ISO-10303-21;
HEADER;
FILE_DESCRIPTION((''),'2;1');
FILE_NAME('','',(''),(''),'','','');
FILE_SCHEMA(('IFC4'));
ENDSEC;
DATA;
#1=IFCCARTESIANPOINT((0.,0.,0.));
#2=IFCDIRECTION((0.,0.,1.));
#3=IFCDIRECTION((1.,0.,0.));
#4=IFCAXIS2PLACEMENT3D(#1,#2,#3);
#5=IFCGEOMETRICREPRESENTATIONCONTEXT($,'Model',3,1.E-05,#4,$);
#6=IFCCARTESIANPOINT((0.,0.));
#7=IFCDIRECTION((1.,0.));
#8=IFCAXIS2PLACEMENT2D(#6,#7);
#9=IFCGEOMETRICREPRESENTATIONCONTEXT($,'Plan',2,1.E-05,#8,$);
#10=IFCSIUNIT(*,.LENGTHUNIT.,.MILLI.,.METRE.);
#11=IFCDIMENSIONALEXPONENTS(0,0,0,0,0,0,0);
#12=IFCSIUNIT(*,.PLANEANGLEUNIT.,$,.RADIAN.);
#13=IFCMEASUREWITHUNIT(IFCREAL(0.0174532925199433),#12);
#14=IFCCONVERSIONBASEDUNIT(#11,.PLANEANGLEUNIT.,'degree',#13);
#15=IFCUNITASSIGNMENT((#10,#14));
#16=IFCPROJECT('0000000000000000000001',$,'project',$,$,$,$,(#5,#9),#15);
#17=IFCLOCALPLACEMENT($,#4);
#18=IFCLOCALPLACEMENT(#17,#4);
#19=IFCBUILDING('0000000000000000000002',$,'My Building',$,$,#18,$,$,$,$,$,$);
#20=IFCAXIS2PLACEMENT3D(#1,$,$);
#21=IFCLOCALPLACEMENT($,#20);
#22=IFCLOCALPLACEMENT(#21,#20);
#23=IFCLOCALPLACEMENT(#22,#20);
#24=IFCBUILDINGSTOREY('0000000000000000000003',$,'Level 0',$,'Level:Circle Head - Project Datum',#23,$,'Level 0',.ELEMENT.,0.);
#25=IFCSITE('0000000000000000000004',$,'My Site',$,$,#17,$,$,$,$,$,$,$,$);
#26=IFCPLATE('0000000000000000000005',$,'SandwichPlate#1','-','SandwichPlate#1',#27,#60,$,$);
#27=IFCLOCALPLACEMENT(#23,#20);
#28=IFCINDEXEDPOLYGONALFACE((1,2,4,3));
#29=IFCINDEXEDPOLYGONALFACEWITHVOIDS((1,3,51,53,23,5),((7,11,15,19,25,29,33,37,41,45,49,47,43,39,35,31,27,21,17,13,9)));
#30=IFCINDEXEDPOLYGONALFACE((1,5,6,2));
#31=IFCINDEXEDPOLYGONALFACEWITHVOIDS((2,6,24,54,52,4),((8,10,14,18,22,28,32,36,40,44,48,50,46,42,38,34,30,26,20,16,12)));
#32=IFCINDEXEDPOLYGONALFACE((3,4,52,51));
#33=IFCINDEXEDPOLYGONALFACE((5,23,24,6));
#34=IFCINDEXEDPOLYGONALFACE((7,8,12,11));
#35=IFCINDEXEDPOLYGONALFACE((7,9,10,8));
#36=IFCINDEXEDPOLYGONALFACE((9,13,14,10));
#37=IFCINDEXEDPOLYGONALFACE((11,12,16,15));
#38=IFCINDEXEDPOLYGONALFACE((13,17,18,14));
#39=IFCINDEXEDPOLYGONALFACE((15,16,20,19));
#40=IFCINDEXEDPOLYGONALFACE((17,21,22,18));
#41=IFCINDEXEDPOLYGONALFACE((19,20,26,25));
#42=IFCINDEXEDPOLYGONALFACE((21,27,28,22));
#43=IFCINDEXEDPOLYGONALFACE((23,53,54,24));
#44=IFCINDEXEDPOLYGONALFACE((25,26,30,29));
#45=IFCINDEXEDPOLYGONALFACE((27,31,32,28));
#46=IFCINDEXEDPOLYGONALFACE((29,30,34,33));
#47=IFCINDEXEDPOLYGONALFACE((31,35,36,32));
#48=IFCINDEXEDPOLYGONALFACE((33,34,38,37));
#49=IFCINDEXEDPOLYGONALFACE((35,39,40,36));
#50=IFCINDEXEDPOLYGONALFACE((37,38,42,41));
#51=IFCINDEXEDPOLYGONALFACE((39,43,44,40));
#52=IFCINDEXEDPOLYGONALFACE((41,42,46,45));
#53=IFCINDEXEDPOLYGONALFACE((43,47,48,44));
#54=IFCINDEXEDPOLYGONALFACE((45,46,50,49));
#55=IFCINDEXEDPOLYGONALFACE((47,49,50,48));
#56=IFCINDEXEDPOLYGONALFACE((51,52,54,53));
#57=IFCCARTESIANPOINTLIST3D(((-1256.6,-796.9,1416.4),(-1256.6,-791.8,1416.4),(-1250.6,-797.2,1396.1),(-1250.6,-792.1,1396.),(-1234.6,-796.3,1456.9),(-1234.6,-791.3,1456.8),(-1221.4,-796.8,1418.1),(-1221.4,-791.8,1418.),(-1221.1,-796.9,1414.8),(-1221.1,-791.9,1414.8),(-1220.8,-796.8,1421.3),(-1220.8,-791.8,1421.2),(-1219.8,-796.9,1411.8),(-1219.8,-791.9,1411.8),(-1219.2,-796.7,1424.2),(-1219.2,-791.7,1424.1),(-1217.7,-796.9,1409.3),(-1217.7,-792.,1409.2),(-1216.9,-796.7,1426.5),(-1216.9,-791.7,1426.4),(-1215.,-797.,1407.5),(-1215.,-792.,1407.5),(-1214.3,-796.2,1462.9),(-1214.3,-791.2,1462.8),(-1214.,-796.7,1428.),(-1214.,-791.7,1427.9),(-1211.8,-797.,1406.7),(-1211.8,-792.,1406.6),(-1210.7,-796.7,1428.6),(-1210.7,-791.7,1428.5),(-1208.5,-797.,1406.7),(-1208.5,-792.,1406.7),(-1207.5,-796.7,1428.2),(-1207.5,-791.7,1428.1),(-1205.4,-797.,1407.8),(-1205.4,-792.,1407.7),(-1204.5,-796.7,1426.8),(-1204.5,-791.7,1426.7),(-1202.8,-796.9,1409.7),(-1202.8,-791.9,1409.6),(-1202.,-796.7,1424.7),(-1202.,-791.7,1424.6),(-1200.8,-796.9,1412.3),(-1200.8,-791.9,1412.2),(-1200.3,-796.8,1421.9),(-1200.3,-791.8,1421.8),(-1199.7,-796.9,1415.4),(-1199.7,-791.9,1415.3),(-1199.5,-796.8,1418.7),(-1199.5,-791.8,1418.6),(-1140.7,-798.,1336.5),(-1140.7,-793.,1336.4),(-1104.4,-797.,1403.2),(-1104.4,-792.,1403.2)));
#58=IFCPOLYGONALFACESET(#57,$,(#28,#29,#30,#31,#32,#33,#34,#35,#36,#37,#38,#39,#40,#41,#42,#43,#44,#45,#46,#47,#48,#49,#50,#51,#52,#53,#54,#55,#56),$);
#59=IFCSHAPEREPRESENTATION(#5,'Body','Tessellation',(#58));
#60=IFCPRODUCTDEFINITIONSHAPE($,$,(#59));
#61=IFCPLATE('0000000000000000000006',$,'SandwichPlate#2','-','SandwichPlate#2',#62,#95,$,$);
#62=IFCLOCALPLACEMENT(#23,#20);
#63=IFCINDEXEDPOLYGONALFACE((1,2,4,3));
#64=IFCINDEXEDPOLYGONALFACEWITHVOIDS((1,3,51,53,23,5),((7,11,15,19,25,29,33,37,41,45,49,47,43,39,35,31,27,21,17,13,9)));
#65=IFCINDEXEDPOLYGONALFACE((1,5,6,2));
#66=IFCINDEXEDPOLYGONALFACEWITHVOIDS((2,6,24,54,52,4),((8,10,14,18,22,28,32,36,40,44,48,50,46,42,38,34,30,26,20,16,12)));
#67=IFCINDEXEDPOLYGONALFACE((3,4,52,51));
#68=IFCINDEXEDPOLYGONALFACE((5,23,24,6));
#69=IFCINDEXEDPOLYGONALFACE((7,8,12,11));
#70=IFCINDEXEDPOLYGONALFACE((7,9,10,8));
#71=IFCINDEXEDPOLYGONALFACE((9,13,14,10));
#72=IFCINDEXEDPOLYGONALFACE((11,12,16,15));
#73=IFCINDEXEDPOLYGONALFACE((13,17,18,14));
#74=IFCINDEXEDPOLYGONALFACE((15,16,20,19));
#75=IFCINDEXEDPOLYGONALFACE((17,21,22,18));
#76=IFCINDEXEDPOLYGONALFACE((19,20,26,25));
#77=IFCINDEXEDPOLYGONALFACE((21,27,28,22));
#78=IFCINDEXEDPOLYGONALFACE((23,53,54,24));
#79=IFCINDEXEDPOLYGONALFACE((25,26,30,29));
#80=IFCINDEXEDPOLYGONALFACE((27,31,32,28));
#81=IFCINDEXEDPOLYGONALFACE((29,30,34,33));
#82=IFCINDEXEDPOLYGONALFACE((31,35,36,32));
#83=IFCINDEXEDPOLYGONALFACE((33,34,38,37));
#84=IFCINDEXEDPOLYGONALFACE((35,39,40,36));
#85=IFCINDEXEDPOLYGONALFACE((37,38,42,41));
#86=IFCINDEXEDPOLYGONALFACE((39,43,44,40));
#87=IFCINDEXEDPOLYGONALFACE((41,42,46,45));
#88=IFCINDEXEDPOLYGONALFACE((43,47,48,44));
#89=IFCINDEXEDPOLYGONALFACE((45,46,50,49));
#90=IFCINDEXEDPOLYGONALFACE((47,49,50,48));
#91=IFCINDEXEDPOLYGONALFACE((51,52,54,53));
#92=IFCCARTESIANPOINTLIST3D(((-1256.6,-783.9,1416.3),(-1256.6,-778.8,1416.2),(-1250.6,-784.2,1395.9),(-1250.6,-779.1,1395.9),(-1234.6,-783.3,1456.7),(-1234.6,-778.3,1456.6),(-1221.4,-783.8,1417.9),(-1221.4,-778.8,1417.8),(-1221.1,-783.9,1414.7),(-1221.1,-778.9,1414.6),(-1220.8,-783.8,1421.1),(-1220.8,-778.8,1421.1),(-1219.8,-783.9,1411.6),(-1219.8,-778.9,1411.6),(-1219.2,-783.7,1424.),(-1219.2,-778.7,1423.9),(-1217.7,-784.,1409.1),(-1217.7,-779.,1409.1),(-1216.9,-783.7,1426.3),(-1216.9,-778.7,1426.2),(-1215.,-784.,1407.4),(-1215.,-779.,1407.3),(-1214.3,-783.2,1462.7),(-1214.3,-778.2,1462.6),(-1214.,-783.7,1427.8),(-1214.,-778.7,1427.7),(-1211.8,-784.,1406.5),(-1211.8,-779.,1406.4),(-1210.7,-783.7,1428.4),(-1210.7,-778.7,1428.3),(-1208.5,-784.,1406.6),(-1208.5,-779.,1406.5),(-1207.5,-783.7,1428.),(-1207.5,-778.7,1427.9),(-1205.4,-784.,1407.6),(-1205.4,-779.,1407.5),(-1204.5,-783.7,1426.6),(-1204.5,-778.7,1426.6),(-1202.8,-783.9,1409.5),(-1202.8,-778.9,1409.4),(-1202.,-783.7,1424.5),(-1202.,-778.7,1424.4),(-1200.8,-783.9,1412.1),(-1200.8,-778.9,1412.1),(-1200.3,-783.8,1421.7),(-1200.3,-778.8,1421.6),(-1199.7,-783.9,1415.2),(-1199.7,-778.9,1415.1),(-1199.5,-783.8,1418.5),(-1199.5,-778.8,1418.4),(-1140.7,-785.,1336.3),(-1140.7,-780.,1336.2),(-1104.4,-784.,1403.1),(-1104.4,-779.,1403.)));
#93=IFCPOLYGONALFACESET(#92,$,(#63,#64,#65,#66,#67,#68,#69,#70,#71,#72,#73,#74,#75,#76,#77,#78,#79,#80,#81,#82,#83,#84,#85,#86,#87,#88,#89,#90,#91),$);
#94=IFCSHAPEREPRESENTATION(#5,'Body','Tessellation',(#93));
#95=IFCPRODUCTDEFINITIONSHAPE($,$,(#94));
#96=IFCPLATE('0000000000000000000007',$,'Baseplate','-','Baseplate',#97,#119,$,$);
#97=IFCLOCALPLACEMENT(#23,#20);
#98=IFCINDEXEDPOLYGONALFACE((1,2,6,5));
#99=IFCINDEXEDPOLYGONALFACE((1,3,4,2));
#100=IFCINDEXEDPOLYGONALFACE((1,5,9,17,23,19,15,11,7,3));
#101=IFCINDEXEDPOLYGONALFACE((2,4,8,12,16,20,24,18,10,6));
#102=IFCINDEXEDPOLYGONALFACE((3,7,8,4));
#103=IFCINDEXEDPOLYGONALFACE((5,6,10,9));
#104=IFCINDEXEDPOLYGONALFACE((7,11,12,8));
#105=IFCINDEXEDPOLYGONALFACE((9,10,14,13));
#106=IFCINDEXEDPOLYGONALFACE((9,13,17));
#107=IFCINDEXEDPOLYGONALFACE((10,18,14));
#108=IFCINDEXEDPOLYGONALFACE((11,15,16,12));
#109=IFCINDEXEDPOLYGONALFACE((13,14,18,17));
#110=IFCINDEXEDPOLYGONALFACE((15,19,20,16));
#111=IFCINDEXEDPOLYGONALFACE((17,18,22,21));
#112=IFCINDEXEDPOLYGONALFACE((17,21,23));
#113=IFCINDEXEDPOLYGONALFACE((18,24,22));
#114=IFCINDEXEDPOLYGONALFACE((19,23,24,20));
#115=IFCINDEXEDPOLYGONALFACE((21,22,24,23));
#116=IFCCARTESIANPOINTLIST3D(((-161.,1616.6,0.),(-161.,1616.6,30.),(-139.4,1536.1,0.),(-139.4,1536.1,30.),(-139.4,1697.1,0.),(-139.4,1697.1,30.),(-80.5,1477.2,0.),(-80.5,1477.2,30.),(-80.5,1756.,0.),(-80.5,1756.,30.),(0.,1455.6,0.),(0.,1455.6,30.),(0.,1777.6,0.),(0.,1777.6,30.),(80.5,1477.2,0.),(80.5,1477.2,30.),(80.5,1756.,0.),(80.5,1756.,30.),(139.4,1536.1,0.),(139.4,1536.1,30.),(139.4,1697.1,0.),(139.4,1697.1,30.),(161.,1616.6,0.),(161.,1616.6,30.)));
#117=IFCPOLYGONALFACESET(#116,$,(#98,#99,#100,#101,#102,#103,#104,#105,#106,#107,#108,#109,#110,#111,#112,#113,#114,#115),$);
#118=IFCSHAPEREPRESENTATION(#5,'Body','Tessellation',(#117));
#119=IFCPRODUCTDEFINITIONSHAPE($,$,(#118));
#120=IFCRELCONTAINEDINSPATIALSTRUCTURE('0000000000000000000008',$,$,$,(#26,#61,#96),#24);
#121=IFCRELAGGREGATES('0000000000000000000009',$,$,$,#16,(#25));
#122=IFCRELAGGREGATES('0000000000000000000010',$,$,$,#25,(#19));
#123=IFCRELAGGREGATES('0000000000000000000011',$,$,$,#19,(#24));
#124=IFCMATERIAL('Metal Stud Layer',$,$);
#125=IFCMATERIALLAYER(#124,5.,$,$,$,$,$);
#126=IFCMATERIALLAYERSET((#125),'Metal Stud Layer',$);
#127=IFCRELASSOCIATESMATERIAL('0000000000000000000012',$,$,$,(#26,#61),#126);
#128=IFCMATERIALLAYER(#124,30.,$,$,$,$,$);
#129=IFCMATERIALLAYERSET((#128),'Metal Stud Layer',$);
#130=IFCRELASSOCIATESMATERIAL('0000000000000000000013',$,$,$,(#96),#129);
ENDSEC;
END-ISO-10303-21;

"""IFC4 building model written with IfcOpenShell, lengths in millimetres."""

from ifc_helpers import new_model, entity, si_unit, converted_unit, point, frame, frame_2d, origin, origin_with_axes, origin_2d_with_axis, place, context, project, spatial, polyline, circle_curve, line_curve, trimmed, segment, composite_curve, circle, outline, extrude, material, layer, layer_set, element, save


model = new_model("IFC4")

# Units and contexts
model_context = context("Model", 3, precision=1e-05, world=origin_with_axes())
plan_context = context("Plan", 2, precision=1e-05, world=origin_2d_with_axis())
ifc_project = project(units=[si_unit("LENGTHUNIT", "METRE", prefix="MILLI"), converted_unit("PLANEANGLEUNIT", "degree", entity("IfcReal", 0.0174532925199433), si_unit("PLANEANGLEUNIT", "RADIAN"), dimensions=[0, 0, 0, 0, 0, 0, 0])], contexts=[model_context, plan_context])

# Site, building, storey
site_placement = place(None, origin_with_axes())
site = spatial("IfcSite", under=ifc_project, at=site_placement, Name="My Site")
building_placement = place(site_placement, origin_with_axes())
building = spatial("IfcBuilding", under=site, at=building_placement, Name="My Building")
placement_1 = place(None, origin())
placement_2 = place(placement_1, origin())
storey_placement = place(placement_2, origin())
storey = spatial("IfcBuildingStorey", under=building, at=storey_placement, Name="Level 0", ObjectType="Level:Circle Head - Project Datum", LongName="Level 0", CompositionType="ELEMENT", Elevation=0.0)

# Shared definitions
ifc_material_1 = material(Name="Metal Stud Layer")
ifc_layer_1 = layer(ifc_material_1, 5.0)
ifc_layer_set_1 = layer_set([ifc_layer_1], Name="Metal Stud Layer")

# Plates, openings
plate_1_placement = place(storey_placement, frame((-1263.7, -797.0, 1403.3), z_axis=(0.0, 0.999896, -0.014432), x_axis=(0.477218, 0.012683, 0.878693)))
plate_1 = element("IfcPlate", 1, at=plate_1_placement, inside=storey, material=ifc_layer_set_1, Name="SandwichPlate#1", Description="-", ObjectType="SandwichPlate#1", context=model_context, shape_type="SweptSolid", body=[
    extrude(outline(polyline([(0.0, 0.0), (76.0, 0.0), (76.0, 140.0), (0.0, 140.0), (0.0, 0.0)])), origin_with_axes(), (0.0, 0.0, 1.0), 5.0),
])
opening_1_placement = place(plate_1_placement, frame((0.0, 0.0, 0.0), z_axis=(0.0, 0.0, 1.0), x_axis=(1.0, 0.0, 0.0)))
element("IfcOpeningElement", 2, at=opening_1_placement, cuts=plate_1, ObjectType="Opening", context=model_context, shape_type="SweptSolid", body=[
    extrude(outline(polyline([(76.0, 0.0), (76.0, 15.0), (61.0, 0.0), (76.0, 0.0)])), origin(), (0.0, 0.0, 1.0), 5.0),
])
opening_2_placement = place(plate_1_placement, frame((38.0, 40.0, -0.5), z_axis=(0.0, 0.0, 1.0), x_axis=(0.0, 1.0, 0.0)))
element("IfcOpeningElement", 3, at=opening_2_placement, cuts=plate_1, ObjectType="Opening", context=model_context, shape_type="SweptSolid", body=[
    extrude(circle(Radius=11.0, at=origin_2d_with_axis()), origin(), (0.0, 0.0, 1.0), 6.0),
])
opening_3_placement = place(plate_1_placement, frame((0.0, 0.0, 0.0), z_axis=(0.0, 0.0, 1.0), x_axis=(1.0, 0.0, 0.0)))
element("IfcOpeningElement", 4, at=opening_3_placement, cuts=plate_1, ObjectType="Opening", context=model_context, shape_type="SweptSolid", body=[
    extrude(outline(polyline([(0.0, 0.0), (15.0, 0.0), (0.0, 15.0), (0.0, 0.0)])), origin(), (0.0, 0.0, 1.0), 5.0),
])
plate_2_placement = place(storey_placement, frame((-1263.7, -784.0, 1403.1), z_axis=(0.0, 0.999896, -0.014432), x_axis=(0.477218, 0.012683, 0.878693)))
plate_2 = element("IfcPlate", 5, at=plate_2_placement, inside=storey, material=ifc_layer_set_1, Name="SandwichPlate#2", Description="-", ObjectType="SandwichPlate#2", context=model_context, shape_type="SweptSolid", body=[
    extrude(outline(polyline([(0.0, 0.0), (76.0, 0.0), (76.0, 140.0), (0.0, 140.0), (0.0, 0.0)])), origin_with_axes(), (0.0, 0.0, 1.0), 5.0),
])
opening_4_placement = place(plate_2_placement, frame((0.0, 0.0, 0.0), z_axis=(0.0, 0.0, 1.0), x_axis=(1.0, 0.0, 0.0)))
element("IfcOpeningElement", 6, at=opening_4_placement, cuts=plate_2, ObjectType="Opening", context=model_context, shape_type="SweptSolid", body=[
    extrude(outline(polyline([(76.0, 0.0), (76.0, 15.0), (61.0, 0.0), (76.0, 0.0)])), origin(), (0.0, 0.0, 1.0), 5.0),
])
opening_5_placement = place(plate_2_placement, frame((38.0, 40.0, -0.5), z_axis=(0.0, 0.0, 1.0), x_axis=(0.0, 1.0, 0.0)))
element("IfcOpeningElement", 7, at=opening_5_placement, cuts=plate_2, ObjectType="Opening", context=model_context, shape_type="SweptSolid", body=[
    extrude(circle(Radius=11.0, at=origin_2d_with_axis()), origin(), (0.0, 0.0, 1.0), 6.0),
])
opening_6_placement = place(plate_2_placement, frame((0.0, 0.0, 0.0), z_axis=(0.0, 0.0, 1.0), x_axis=(1.0, 0.0, 0.0)))
element("IfcOpeningElement", 8, at=opening_6_placement, cuts=plate_2, ObjectType="Opening", context=model_context, shape_type="SweptSolid", body=[
    extrude(outline(polyline([(0.0, 0.0), (15.0, 0.0), (0.0, 15.0), (0.0, 0.0)])), origin(), (0.0, 0.0, 1.0), 5.0),
])
ifc_layer_2 = layer(ifc_material_1, 30.0)
ifc_layer_set_2 = layer_set([ifc_layer_2], Name="Metal Stud Layer")
plate_3_placement = place(storey_placement, frame((-161.0, 1616.6, 30.0), z_axis=(0.0, 0.0, -1.0), x_axis=(0.0, 1.0, 0.0)))
plate_3 = element("IfcPlate", 9, at=plate_3_placement, inside=storey, material=ifc_layer_set_2, Name="Baseplate", Description="-", ObjectType="Baseplate", context=model_context, shape_type="SweptSolid", body=[
    extrude(outline(polyline([(161.0, 0.0), (161.0, 322.0), (-161.0, 322.0), (-161.0, 0.0), (161.0, 0.0)])), origin_with_axes(), (0.0, 0.0, 1.0), 30.0),
])
opening_7_placement = place(plate_3_placement, frame((0.0, 0.0, 0.0), z_axis=(0.0, 0.0, 1.0), x_axis=(1.0, 0.0, 0.0)))
element("IfcOpeningElement", 10, at=opening_7_placement, cuts=plate_3, ObjectType="Opening", context=model_context, shape_type="SweptSolid", body=[
    extrude(outline(composite_curve([segment(trimmed(line_curve((-161.0, 0.0), (1.0, 0.0), 161.0), [point((-161.0, 0.0))], [point((0.0, 0.0))], True, "CARTESIAN"), True, "CONTINUOUS"), segment(trimmed(circle_curve(frame_2d((0.0, 161.0), x_axis=(-1.0, 0.0)), 161.0), [point((0.0, 0.0))], [point((-161.0, 161.0))], False, "CARTESIAN"), True, "CONTINUOUS"), segment(trimmed(line_curve((-161.0, 161.0), (0.0, -1.0), 161.0), [point((-161.0, 161.0))], [point((-161.0, 0.0))], True, "CARTESIAN"), True, "CONTINUOUS")], self_intersect=False)), origin(), (0.0, 0.0, 1.0), 30.0),
])
opening_8_placement = place(plate_3_placement, frame((0.0, 0.0, 0.0), z_axis=(0.0, 0.0, 1.0), x_axis=(1.0, 0.0, 0.0)))
element("IfcOpeningElement", 11, at=opening_8_placement, cuts=plate_3, ObjectType="Opening", context=model_context, shape_type="SweptSolid", body=[
    extrude(outline(composite_curve([segment(trimmed(line_curve((161.0, 322.0), (-1.0, 0.0), 161.0), [point((161.0, 322.0))], [point((0.0, 322.0))], True, "CARTESIAN"), True, "CONTINUOUS"), segment(trimmed(circle_curve(frame_2d((0.0, 161.0), x_axis=(-1.0, 0.0)), 161.0), [point((0.0, 322.0))], [point((161.0, 161.0))], False, "CARTESIAN"), True, "CONTINUOUS"), segment(trimmed(line_curve((161.0, 161.0), (0.0, 1.0), 161.0), [point((161.0, 161.0))], [point((161.0, 322.0))], True, "CARTESIAN"), True, "CONTINUOUS")], self_intersect=False)), origin(), (0.0, 0.0, 1.0), 30.0),
])
opening_9_placement = place(plate_3_placement, frame((0.0, 0.0, 0.0), z_axis=(0.0, 0.0, 1.0), x_axis=(1.0, 0.0, 0.0)))
element("IfcOpeningElement", 12, at=opening_9_placement, cuts=plate_3, ObjectType="Opening", context=model_context, shape_type="SweptSolid", body=[
    extrude(outline(composite_curve([segment(trimmed(line_curve((-161.0, 322.0), (0.0, -1.0), 161.0), [point((-161.0, 322.0))], [point((-161.0, 161.0))], True, "CARTESIAN"), True, "CONTINUOUS"), segment(trimmed(circle_curve(frame_2d((0.0, 161.0), x_axis=(-1.0, 0.0)), 161.0), [point((-161.0, 161.0))], [point((0.0, 322.0))], False, "CARTESIAN"), True, "CONTINUOUS"), segment(trimmed(line_curve((0.0, 322.0), (-1.0, 0.0), 161.0), [point((0.0, 322.0))], [point((-161.0, 322.0))], True, "CARTESIAN"), True, "CONTINUOUS")], self_intersect=False)), origin(), (0.0, 0.0, 1.0), 30.0),
])
opening_10_placement = place(plate_3_placement, frame((0.0, 0.0, 0.0), z_axis=(0.0, 0.0, 1.0), x_axis=(1.0, 0.0, 0.0)))
element("IfcOpeningElement", 13, at=opening_10_placement, cuts=plate_3, ObjectType="Opening", context=model_context, shape_type="SweptSolid", body=[
    extrude(outline(composite_curve([segment(trimmed(line_curve((161.0, 0.0), (0.0, 1.0), 161.0), [point((161.0, 0.0))], [point((161.0, 161.0))], True, "CARTESIAN"), True, "CONTINUOUS"), segment(trimmed(circle_curve(frame_2d((0.0, 161.0), x_axis=(-1.0, 0.0)), 161.0), [point((161.0, 161.0))], [point((0.0, 0.0))], False, "CARTESIAN"), True, "CONTINUOUS"), segment(trimmed(line_curve((0.0, 0.0), (1.0, 0.0), 161.0), [point((0.0, 0.0))], [point((161.0, 0.0))], True, "CARTESIAN"), True, "CONTINUOUS")], self_intersect=False)), origin(), (0.0, 0.0, 1.0), 30.0),
])

save(model, "model.ifc")
